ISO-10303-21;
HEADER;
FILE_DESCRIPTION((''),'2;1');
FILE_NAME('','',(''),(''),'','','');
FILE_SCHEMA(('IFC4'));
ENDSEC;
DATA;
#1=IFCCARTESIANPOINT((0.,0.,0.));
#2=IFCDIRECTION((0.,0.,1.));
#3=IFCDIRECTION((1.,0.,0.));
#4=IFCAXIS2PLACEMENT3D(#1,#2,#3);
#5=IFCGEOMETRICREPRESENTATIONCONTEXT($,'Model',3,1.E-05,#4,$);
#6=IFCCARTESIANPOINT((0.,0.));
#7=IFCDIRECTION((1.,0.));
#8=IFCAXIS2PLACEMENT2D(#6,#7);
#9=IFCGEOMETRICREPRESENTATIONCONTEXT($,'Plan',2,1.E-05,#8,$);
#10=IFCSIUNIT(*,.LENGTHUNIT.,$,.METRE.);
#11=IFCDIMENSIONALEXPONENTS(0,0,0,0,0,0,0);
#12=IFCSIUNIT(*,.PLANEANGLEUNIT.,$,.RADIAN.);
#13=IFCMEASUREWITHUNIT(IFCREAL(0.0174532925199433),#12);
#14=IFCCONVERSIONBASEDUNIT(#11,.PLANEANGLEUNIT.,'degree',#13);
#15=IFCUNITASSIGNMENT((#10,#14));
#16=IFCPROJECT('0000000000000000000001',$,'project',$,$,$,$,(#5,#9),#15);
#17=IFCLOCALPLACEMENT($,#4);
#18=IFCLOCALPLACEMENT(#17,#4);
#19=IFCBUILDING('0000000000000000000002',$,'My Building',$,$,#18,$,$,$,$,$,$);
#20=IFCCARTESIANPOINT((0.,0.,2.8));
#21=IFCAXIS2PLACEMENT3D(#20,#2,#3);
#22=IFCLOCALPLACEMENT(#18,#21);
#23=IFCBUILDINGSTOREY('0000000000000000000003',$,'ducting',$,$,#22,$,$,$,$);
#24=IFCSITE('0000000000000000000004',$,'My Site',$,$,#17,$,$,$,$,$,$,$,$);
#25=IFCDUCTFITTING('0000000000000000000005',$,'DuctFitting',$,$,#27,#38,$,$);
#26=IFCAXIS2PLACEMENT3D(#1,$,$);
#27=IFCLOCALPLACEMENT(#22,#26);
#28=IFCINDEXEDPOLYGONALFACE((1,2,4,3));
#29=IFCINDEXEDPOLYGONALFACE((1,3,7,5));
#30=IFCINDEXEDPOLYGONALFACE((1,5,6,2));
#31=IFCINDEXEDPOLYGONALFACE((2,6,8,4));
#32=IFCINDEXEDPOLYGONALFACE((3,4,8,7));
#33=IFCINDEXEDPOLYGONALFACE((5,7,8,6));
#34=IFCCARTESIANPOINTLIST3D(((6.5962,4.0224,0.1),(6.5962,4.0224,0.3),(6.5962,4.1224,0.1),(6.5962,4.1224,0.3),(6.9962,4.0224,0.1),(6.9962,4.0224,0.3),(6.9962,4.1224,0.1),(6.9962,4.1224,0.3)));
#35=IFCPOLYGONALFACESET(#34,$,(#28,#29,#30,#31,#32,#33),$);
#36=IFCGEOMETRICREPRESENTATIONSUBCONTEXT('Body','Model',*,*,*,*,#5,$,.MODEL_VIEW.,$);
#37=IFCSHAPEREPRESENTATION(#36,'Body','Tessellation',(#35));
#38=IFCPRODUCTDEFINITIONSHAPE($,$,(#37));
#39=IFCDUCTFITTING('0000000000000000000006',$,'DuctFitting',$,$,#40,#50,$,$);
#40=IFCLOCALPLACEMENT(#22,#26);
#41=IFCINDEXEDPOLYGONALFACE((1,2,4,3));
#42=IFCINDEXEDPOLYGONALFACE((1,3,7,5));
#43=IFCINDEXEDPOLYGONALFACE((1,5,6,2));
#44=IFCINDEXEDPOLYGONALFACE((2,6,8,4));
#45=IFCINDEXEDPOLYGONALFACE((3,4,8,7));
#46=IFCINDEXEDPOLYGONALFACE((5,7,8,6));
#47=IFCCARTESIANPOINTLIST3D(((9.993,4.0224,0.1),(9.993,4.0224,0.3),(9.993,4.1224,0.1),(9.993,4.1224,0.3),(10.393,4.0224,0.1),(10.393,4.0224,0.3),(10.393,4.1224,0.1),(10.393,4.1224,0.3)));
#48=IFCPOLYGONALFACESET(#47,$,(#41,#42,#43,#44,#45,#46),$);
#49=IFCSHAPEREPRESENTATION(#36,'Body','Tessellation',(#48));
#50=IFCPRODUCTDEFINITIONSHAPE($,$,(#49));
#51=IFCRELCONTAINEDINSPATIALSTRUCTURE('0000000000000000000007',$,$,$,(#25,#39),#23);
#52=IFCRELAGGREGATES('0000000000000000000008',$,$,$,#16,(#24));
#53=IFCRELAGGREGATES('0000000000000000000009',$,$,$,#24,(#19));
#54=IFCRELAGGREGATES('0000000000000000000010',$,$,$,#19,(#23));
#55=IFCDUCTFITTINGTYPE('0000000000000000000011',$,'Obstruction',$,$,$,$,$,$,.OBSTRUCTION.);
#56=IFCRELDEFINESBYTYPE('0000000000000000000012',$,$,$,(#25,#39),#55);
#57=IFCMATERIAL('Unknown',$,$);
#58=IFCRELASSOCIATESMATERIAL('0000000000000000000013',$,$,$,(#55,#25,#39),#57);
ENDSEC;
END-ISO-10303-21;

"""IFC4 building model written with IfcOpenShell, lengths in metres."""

from ifc_helpers import new_model, entity, si_unit, converted_unit, frame, origin_with_axes, origin_2d_with_axis, place, context, subcontext, project, spatial, rectangle, extrude, material, material_profile, profile_set, profile_usage, type_object, element, save


model = new_model("IFC4")

# Units and contexts
model_context = context("Model", 3, precision=1e-05, world=origin_with_axes())
plan_context = context("Plan", 2, precision=1e-05, world=origin_2d_with_axis())
body_context = subcontext(model_context, "Body", "Model", "MODEL_VIEW")
ifc_project = project(units=[si_unit("LENGTHUNIT", "METRE"), converted_unit("PLANEANGLEUNIT", "degree", entity("IfcReal", 0.0174532925199433), si_unit("PLANEANGLEUNIT", "RADIAN"), dimensions=[0, 0, 0, 0, 0, 0, 0])], contexts=[model_context, plan_context])

# Site, building, storey
site_placement = place(None, origin_with_axes())
site = spatial("IfcSite", under=ifc_project, at=site_placement, Name="My Site")
building_placement = place(site_placement, origin_with_axes())
building = spatial("IfcBuilding", under=site, at=building_placement, Name="My Building")
storey_placement = place(building_placement, frame((0.0, 0.0, 2.8), z_axis=(0.0, 0.0, 1.0), x_axis=(1.0, 0.0, 0.0)))
storey = spatial("IfcBuildingStorey", under=building, at=storey_placement, Name="ducting")

# Shared definitions
ifc_material = material(Name="Unknown")

# Duct fittings
ifc_material_profile_1 = material_profile(ifc_material, rectangle(XDim=0.4, YDim=0.2))
ifc_profile_set_1 = profile_set([ifc_material_profile_1])
duct_fitting_type_1 = type_object("IfcDuctFittingType", Name="Obstruction", PredefinedType="OBSTRUCTION", material=ifc_profile_set_1)
ifc_profile_usage_1 = profile_usage(ifc_profile_set_1, cardinal=5)
duct_fitting_1_placement = place(storey_placement, frame((6.7962, 4.0224, 0.2), z_axis=(0.0, 1.0, 0.0), x_axis=(-1.0, 0.0, 0.0)))
element("IfcDuctFitting", 1, at=duct_fitting_1_placement, inside=storey, type_object=duct_fitting_type_1, material=ifc_profile_usage_1, Name="DuctFitting", context=body_context, shape_type="SweptSolid", body=[
    extrude(rectangle(XDim=0.4, YDim=0.2), origin_with_axes(), (0.0, 0.0, 1.0), 0.1),
])
ifc_profile_usage_2 = profile_usage(ifc_profile_set_1, cardinal=5)
duct_fitting_2_placement = place(storey_placement, frame((10.193, 4.0224, 0.2), z_axis=(0.0, 1.0, 0.0), x_axis=(1.0, 0.0, 0.0)))
element("IfcDuctFitting", 2, at=duct_fitting_2_placement, inside=storey, type_object=duct_fitting_type_1, material=ifc_profile_usage_2, Name="DuctFitting", context=body_context, shape_type="SweptSolid", body=[
    extrude(rectangle(XDim=0.4, YDim=0.2), origin_with_axes(), (0.0, 0.0, 1.0), 0.1),
])

save(model, "model.ifc")
